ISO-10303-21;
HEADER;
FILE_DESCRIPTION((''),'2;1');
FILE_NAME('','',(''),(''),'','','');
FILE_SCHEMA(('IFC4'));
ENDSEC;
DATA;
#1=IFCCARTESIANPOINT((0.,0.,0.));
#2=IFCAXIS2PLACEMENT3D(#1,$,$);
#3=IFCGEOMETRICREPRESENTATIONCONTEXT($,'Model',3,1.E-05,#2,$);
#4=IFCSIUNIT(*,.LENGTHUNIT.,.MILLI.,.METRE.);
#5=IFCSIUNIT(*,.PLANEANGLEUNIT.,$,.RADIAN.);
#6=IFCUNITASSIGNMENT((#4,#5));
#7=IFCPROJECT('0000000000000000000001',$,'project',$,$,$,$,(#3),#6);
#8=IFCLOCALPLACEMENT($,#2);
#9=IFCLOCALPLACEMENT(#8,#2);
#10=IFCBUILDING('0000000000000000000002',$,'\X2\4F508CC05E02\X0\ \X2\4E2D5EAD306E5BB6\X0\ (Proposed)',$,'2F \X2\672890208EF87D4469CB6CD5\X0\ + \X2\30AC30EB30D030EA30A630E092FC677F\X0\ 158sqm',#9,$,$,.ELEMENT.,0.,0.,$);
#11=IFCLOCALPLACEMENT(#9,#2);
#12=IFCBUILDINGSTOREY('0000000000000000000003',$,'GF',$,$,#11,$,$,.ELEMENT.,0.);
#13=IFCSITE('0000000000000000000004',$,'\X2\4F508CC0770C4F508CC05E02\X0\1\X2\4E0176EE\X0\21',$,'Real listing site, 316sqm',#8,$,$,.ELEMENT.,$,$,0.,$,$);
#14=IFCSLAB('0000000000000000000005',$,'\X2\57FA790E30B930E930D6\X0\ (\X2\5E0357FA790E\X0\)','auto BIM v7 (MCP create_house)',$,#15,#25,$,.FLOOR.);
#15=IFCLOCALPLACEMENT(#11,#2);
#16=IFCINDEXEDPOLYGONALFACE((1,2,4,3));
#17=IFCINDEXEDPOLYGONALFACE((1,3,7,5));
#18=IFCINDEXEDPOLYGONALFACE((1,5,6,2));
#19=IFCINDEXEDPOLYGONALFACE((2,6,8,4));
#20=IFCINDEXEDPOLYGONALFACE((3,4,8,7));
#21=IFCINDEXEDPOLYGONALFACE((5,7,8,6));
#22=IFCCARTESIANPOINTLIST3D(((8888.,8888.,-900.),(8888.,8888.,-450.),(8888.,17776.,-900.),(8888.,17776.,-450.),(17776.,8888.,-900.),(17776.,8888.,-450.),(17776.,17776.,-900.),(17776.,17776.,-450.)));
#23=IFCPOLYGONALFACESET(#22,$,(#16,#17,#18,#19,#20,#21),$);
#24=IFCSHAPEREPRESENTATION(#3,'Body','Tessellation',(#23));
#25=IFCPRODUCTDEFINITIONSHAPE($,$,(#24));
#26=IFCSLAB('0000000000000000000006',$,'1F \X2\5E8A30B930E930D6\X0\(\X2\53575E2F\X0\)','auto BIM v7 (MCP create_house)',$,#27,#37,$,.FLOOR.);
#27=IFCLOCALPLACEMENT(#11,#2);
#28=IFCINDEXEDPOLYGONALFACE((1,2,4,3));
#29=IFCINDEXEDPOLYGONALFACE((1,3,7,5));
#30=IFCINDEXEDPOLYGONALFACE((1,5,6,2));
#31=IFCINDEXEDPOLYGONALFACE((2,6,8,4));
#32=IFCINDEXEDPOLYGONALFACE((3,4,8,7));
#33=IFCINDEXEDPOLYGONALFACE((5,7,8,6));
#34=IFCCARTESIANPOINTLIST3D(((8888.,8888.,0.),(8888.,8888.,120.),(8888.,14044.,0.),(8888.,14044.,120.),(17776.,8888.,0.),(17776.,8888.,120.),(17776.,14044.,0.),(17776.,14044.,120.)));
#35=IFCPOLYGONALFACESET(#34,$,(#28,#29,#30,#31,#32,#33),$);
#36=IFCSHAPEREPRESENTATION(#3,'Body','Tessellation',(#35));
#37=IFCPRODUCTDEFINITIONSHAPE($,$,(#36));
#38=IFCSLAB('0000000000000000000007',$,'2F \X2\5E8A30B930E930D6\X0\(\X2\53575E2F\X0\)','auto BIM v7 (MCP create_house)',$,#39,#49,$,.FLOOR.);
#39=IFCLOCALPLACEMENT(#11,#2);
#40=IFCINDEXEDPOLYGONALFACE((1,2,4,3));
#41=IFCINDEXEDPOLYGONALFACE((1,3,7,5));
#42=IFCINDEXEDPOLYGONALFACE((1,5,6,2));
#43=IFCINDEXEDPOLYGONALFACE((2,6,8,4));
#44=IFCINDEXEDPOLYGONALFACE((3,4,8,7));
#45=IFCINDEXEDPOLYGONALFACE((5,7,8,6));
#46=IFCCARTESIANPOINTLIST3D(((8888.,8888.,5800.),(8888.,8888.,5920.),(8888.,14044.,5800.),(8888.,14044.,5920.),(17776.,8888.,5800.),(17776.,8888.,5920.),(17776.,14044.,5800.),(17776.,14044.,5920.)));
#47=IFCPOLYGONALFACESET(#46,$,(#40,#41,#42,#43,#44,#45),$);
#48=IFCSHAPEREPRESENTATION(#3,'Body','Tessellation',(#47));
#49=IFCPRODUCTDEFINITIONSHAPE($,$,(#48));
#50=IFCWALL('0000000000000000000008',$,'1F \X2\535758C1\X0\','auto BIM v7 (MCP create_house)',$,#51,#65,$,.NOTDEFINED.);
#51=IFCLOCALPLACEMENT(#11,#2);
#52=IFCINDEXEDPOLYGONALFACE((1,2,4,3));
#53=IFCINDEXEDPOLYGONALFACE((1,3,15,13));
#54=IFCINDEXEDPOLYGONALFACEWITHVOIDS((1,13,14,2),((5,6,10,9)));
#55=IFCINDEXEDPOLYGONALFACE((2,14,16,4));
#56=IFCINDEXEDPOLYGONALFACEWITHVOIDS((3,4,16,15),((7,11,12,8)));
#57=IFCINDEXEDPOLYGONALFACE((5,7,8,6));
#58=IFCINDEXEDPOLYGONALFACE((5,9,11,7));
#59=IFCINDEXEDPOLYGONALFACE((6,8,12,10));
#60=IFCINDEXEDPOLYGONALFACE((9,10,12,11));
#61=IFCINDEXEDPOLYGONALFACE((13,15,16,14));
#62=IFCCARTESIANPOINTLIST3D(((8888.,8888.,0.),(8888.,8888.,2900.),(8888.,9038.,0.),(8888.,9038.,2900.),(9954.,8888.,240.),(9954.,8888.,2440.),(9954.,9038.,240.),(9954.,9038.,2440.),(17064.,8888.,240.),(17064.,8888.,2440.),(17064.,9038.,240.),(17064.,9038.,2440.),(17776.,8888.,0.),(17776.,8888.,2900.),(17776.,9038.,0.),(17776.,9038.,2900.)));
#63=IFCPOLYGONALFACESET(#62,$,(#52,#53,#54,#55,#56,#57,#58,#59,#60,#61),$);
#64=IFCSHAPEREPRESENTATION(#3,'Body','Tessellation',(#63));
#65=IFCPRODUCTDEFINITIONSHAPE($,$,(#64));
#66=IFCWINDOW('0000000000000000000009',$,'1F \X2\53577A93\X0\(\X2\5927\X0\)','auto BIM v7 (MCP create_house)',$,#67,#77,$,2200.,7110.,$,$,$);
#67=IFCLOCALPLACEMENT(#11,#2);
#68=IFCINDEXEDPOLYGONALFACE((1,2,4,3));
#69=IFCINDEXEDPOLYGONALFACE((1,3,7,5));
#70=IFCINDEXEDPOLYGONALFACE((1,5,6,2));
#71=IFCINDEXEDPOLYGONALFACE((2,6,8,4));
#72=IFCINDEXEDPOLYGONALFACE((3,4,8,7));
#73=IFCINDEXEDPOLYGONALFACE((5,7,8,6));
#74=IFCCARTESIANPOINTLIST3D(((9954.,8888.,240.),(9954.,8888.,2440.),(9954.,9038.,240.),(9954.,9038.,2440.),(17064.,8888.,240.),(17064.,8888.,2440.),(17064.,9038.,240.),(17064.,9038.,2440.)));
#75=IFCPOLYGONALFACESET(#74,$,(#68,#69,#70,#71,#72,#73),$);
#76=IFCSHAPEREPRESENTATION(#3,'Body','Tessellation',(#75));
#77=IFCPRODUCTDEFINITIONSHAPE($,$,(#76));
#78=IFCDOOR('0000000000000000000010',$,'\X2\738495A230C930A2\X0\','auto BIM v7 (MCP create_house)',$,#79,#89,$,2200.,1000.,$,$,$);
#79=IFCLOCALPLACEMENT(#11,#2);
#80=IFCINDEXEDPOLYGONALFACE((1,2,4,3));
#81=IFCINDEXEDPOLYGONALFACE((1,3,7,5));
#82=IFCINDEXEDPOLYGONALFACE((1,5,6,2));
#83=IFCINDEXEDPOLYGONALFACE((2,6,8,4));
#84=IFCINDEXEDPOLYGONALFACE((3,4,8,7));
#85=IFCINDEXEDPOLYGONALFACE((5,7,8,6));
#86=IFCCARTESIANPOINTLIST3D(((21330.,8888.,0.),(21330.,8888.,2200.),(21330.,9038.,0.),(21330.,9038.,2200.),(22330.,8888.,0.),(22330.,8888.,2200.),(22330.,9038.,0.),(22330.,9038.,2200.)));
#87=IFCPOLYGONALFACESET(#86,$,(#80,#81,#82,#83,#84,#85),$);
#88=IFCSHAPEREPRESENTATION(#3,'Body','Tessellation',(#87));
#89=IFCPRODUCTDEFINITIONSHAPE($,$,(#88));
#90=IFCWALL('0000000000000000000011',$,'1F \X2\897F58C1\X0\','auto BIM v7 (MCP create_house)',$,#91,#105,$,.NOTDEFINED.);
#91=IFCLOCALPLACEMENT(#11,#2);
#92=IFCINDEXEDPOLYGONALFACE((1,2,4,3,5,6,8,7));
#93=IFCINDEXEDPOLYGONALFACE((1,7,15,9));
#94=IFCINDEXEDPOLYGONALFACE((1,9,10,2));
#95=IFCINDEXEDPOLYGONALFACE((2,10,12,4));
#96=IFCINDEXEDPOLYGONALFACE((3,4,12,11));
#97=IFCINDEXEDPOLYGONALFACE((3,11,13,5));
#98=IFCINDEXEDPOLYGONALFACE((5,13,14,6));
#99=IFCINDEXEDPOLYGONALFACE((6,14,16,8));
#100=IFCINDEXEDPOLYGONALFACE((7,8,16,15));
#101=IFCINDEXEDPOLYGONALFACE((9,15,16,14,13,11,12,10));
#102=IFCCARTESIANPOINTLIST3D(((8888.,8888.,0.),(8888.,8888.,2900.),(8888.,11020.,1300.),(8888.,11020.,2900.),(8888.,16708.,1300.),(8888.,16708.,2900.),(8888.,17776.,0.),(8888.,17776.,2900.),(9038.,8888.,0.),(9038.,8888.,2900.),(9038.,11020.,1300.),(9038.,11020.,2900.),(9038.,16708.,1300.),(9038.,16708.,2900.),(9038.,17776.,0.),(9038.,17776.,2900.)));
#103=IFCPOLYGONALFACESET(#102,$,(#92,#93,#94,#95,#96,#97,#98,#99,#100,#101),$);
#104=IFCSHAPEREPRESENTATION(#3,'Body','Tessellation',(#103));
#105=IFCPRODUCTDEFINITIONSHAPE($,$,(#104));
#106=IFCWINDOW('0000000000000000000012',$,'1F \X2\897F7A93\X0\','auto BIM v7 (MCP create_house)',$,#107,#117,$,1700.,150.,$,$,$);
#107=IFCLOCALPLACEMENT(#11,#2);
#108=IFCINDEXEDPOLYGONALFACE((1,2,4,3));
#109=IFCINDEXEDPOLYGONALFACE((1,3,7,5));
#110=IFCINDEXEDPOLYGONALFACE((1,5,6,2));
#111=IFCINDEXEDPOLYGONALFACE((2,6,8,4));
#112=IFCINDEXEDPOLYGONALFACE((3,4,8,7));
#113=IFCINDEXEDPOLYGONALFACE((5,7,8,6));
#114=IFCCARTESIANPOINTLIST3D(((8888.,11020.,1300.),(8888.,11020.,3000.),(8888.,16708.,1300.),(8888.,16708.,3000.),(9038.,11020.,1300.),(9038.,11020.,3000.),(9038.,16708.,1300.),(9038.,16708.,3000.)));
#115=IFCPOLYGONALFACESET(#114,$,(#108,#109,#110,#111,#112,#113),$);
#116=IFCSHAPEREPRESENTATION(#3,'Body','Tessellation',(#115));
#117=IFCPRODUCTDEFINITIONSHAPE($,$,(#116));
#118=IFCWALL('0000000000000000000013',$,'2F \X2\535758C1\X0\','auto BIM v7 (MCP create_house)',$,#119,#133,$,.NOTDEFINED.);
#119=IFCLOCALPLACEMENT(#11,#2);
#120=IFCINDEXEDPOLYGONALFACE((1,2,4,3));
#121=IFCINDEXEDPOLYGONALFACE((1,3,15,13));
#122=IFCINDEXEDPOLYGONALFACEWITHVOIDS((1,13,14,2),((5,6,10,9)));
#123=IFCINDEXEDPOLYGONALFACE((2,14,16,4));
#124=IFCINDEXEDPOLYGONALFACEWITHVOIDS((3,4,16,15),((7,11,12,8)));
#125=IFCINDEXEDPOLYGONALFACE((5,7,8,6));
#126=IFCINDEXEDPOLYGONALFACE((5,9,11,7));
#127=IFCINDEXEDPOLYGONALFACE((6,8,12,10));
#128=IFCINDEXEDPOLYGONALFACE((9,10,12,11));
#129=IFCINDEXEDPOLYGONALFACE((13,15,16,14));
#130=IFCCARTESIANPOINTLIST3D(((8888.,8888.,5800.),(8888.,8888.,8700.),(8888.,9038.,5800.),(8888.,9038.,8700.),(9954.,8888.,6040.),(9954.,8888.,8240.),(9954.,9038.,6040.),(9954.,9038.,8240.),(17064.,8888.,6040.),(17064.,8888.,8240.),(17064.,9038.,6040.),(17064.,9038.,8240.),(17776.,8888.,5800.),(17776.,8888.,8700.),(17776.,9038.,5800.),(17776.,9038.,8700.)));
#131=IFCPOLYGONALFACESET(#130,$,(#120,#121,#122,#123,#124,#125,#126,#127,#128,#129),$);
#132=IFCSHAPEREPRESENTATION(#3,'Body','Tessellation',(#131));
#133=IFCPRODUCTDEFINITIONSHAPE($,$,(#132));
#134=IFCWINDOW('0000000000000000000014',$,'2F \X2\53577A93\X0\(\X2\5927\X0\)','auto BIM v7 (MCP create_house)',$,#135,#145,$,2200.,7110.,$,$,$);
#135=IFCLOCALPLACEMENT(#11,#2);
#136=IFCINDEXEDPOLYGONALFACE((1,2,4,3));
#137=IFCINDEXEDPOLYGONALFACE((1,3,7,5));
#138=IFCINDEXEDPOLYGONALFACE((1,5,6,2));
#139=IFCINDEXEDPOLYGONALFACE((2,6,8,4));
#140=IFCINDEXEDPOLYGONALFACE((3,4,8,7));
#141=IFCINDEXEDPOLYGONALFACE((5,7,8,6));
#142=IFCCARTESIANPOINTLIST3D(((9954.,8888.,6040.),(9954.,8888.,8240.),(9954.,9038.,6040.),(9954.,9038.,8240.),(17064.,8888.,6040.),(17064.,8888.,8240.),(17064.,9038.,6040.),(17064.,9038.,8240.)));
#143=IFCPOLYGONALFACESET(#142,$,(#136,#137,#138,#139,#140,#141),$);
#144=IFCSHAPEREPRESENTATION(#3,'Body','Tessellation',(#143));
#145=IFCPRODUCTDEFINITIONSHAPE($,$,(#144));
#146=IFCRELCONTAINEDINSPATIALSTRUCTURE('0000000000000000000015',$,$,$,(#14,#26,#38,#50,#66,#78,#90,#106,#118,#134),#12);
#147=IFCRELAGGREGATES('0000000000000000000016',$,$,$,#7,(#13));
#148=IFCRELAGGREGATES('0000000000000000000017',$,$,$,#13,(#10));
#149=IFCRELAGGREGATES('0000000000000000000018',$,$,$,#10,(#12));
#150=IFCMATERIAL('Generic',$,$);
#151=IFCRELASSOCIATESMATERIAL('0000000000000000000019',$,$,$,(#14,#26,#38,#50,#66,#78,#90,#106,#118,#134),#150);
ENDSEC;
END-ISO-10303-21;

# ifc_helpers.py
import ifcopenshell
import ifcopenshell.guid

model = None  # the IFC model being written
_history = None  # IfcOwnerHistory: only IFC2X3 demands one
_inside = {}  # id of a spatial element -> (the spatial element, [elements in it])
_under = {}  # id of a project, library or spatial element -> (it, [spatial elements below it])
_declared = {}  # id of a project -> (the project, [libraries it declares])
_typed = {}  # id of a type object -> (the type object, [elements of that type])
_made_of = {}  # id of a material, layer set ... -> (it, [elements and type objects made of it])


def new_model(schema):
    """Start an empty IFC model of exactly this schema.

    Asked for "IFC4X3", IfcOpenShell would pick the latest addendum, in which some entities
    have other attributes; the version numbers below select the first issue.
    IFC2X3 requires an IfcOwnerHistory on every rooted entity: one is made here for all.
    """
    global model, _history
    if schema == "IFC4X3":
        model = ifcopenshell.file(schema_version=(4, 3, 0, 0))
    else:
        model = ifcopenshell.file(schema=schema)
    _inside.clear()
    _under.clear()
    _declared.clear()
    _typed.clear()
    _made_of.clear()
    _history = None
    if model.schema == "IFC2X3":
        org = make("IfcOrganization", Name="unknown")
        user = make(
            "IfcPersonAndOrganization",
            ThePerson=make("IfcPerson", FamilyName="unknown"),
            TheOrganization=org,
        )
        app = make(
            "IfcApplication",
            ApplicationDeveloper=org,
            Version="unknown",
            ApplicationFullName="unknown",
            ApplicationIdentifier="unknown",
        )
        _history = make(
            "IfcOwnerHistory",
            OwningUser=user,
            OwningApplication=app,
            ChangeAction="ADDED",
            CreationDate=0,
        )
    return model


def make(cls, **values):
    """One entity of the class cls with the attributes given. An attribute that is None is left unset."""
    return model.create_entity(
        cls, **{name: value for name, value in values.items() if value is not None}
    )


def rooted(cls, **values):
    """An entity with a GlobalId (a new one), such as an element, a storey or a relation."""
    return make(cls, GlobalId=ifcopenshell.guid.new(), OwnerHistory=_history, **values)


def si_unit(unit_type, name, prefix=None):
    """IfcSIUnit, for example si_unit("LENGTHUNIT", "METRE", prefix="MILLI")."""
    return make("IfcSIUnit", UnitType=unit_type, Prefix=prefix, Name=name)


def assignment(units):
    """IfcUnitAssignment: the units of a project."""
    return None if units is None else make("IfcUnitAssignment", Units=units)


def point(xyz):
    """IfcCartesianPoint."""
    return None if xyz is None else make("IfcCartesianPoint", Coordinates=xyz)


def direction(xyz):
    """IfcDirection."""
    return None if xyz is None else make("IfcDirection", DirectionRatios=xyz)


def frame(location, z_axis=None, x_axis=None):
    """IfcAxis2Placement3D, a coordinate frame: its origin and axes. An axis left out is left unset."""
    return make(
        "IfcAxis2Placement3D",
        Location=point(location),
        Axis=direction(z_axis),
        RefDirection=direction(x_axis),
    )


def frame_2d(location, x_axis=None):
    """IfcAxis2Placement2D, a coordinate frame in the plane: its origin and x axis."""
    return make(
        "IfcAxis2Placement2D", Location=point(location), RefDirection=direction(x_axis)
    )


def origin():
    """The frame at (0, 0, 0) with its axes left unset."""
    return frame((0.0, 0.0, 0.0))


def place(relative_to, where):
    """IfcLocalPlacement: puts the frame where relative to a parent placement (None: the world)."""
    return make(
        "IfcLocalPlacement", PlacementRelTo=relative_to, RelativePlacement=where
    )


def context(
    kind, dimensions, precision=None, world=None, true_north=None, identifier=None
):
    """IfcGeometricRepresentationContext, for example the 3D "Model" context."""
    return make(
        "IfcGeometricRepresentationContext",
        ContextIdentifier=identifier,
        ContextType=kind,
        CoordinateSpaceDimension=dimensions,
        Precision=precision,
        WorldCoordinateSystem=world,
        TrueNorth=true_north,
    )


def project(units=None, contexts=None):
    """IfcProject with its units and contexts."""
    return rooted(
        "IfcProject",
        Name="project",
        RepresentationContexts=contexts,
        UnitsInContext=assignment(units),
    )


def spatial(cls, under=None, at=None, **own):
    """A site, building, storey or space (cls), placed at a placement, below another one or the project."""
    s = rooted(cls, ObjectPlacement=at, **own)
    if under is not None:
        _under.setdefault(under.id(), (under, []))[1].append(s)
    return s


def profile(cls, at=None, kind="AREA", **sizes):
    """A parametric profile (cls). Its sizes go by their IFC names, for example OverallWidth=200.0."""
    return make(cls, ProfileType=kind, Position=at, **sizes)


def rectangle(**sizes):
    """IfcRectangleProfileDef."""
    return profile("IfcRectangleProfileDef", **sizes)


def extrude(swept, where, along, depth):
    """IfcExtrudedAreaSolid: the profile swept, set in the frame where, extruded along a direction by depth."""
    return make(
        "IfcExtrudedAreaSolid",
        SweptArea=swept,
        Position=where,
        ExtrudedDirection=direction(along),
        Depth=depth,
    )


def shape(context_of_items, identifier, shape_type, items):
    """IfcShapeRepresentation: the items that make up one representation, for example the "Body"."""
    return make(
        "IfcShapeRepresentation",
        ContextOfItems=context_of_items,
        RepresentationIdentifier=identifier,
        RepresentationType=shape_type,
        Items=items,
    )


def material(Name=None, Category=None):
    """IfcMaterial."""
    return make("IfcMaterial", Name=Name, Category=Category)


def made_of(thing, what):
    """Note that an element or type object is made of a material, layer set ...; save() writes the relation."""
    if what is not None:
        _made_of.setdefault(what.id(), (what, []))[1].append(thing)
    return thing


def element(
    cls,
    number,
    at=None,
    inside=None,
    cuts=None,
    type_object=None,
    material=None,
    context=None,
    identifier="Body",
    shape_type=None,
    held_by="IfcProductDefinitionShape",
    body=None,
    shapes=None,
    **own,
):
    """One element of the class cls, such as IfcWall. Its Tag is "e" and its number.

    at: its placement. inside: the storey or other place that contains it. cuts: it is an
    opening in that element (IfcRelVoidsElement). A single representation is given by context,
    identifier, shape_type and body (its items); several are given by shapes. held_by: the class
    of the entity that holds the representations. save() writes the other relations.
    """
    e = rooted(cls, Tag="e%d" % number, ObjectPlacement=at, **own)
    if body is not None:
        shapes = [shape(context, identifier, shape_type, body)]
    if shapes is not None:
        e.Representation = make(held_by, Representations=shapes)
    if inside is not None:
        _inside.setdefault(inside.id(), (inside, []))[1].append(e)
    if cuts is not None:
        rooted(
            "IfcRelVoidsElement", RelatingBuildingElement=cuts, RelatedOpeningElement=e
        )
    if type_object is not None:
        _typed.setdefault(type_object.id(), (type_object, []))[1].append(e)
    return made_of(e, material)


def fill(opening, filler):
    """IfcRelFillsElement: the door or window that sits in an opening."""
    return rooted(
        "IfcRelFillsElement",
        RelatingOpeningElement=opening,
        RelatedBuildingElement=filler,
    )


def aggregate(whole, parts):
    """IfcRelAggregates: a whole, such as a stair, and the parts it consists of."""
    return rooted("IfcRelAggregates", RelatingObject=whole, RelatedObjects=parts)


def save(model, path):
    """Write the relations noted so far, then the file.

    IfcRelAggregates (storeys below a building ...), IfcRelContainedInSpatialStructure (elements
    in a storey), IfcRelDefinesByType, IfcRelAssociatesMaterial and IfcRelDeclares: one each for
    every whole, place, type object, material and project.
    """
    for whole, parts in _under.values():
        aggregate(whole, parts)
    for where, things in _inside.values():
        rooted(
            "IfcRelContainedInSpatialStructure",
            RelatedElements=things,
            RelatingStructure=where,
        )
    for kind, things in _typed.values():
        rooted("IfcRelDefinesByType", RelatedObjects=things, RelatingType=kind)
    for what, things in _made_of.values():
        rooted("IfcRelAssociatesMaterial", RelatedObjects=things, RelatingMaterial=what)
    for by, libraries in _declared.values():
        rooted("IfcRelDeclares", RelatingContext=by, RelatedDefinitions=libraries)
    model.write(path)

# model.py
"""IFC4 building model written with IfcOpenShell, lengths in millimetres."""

from ifc_helpers import new_model, si_unit, frame, frame_2d, origin, place, context, project, spatial, rectangle, extrude, material, element, fill, save


model = new_model("IFC4")

# Units and contexts
model_context = context("Model", 3, precision=1e-05, world=origin())
ifc_project = project(units=[si_unit("LENGTHUNIT", "METRE", prefix="MILLI"), si_unit("PLANEANGLEUNIT", "RADIAN")], contexts=[model_context])

# Site, building, storey
site_placement = place(None, origin())
site = spatial("IfcSite", under=ifc_project, at=site_placement, Name="佐賀県佐賀市1丁目21", ObjectType="Real listing site, 316sqm", CompositionType="ELEMENT", RefElevation=0.0)
building_placement = place(site_placement, origin())
building = spatial("IfcBuilding", under=site, at=building_placement, Name="佐賀市 中庭の家 (Proposed)", ObjectType="2F 木造軸組構法 + ガルバリウム鋼板 158sqm", CompositionType="ELEMENT", ElevationOfRefHeight=0.0, ElevationOfTerrain=0.0)
storey_placement = place(building_placement, origin())
storey = spatial("IfcBuildingStorey", under=building, at=storey_placement, Name="GF", CompositionType="ELEMENT", Elevation=0.0)

# Slabs
ifc_material = material(Name="Generic")
slab_1_placement = place(storey_placement, frame((4444.0, 4444.0, -450.0)))
element("IfcSlab", 1, at=slab_1_placement, inside=storey, material=ifc_material, Name="基礎スラブ (布基礎)", Description="auto BIM v7 (MCP create_house)", PredefinedType="FLOOR", context=model_context, shape_type="SweptSolid", body=[
    extrude(rectangle(XDim=8888.0, YDim=8888.0, at=frame_2d((4444.0, 4444.0))), frame((4444.0, 4444.0, -450.0)), (0.0, 0.0, 1.0), 450.0),
])
slab_2_placement = place(storey_placement, frame((4444.0, 4444.0, 0.0)))
element("IfcSlab", 2, at=slab_2_placement, inside=storey, material=ifc_material, Name="1F 床スラブ(南帯)", Description="auto BIM v7 (MCP create_house)", PredefinedType="FLOOR", context=model_context, shape_type="SweptSolid", body=[
    extrude(rectangle(XDim=8888.0, YDim=5156.0, at=frame_2d((4444.0, 2578.0))), frame((4444.0, 4444.0, 0.0)), (0.0, 0.0, 1.0), 120.0),
])
slab_3_placement = place(storey_placement, frame((4444.0, 4444.0, 2900.0)))
element("IfcSlab", 3, at=slab_3_placement, inside=storey, material=ifc_material, Name="2F 床スラブ(南帯)", Description="auto BIM v7 (MCP create_house)", PredefinedType="FLOOR", context=model_context, shape_type="SweptSolid", body=[
    extrude(rectangle(XDim=8888.0, YDim=5156.0, at=frame_2d((4444.0, 2578.0))), frame((4444.0, 4444.0, 2900.0)), (0.0, 0.0, 1.0), 120.0),
])

# Wall, openings, window, door
wall_1_placement = place(storey_placement, frame((4444.0, 4444.0, 0.0)))
wall_1 = element("IfcWall", 4, at=wall_1_placement, inside=storey, material=ifc_material, Name="1F 南壁", Description="auto BIM v7 (MCP create_house)", PredefinedType="NOTDEFINED", context=model_context, shape_type="SweptSolid", body=[
    extrude(rectangle(XDim=8888.0, YDim=150.0, at=frame_2d((4444.0, 75.0))), frame((4444.0, 4444.0, 0.0)), (0.0, 0.0, 1.0), 2900.0),
])
opening_1_placement = place(storey_placement, frame((4977.0, 4444.0, 120.0)))
opening_1 = element("IfcOpeningElement", 5, at=opening_1_placement, cuts=wall_1, PredefinedType="NOTDEFINED", context=model_context, shape_type="SweptSolid", body=[
    extrude(rectangle(XDim=7110.0, YDim=150.0, at=frame_2d((3555.0, 75.0))), frame((4977.0, 4444.0, 120.0)), (0.0, 0.0, 1.0), 2200.0),
])
opening_2_placement = place(storey_placement, frame((10665.0, 4444.0, 0.0)))
opening_2 = element("IfcOpeningElement", 6, at=opening_2_placement, cuts=wall_1, PredefinedType="NOTDEFINED", context=model_context, shape_type="SweptSolid", body=[
    extrude(rectangle(XDim=1000.0, YDim=150.0, at=frame_2d((500.0, 75.0))), frame((10665.0, 4444.0, 0.0)), (0.0, 0.0, 1.0), 2200.0),
])
window_1_placement = place(storey_placement, frame((4977.0, 4444.0, 120.0)))
window_1 = element("IfcWindow", 7, at=window_1_placement, inside=storey, material=ifc_material, Name="1F 南窓(大)", Description="auto BIM v7 (MCP create_house)", OverallHeight=2200.0, OverallWidth=7110.0, context=model_context, shape_type="SweptSolid", body=[
    extrude(rectangle(XDim=7110.0, YDim=150.0, at=frame_2d((3555.0, 75.0))), frame((4977.0, 4444.0, 120.0)), (0.0, 0.0, 1.0), 2200.0),
])
fill(opening_1, window_1)
door_placement = place(storey_placement, frame((10665.0, 4444.0, 0.0)))
door = element("IfcDoor", 8, at=door_placement, inside=storey, material=ifc_material, Name="玄関ドア", Description="auto BIM v7 (MCP create_house)", OverallHeight=2200.0, OverallWidth=1000.0, context=model_context, shape_type="SweptSolid", body=[
    extrude(rectangle(XDim=1000.0, YDim=150.0, at=frame_2d((500.0, 75.0))), frame((10665.0, 4444.0, 0.0)), (0.0, 0.0, 1.0), 2200.0),
])
fill(opening_2, door)

# Wall, opening, window
wall_2_placement = place(storey_placement, frame((4444.0, 4444.0, 0.0)))
wall_2 = element("IfcWall", 9, at=wall_2_placement, inside=storey, material=ifc_material, Name="1F 西壁", Description="auto BIM v7 (MCP create_house)", PredefinedType="NOTDEFINED", context=model_context, shape_type="SweptSolid", body=[
    extrude(rectangle(XDim=150.0, YDim=8888.0, at=frame_2d((75.0, 4444.0))), frame((4444.0, 4444.0, 0.0)), (0.0, 0.0, 1.0), 2900.0),
])
opening_3_placement = place(storey_placement, frame((4444.0, 5510.0, 650.0)))
opening_3 = element("IfcOpeningElement", 10, at=opening_3_placement, cuts=wall_2, PredefinedType="NOTDEFINED", context=model_context, shape_type="SweptSolid", body=[
    extrude(rectangle(XDim=150.0, YDim=5688.0, at=frame_2d((75.0, 2844.0))), frame((4444.0, 5510.0, 650.0)), (0.0, 0.0, 1.0), 1700.0),
])
window_2_placement = place(storey_placement, frame((4444.0, 5510.0, 650.0)))
window_2 = element("IfcWindow", 11, at=window_2_placement, inside=storey, material=ifc_material, Name="1F 西窓", Description="auto BIM v7 (MCP create_house)", OverallHeight=1700.0, OverallWidth=150.0, context=model_context, shape_type="SweptSolid", body=[
    extrude(rectangle(XDim=150.0, YDim=5688.0, at=frame_2d((75.0, 2844.0))), frame((4444.0, 5510.0, 650.0)), (0.0, 0.0, 1.0), 1700.0),
])
fill(opening_3, window_2)

# Wall, opening, window
wall_3_placement = place(storey_placement, frame((4444.0, 4444.0, 2900.0)))
wall_3 = element("IfcWall", 12, at=wall_3_placement, inside=storey, material=ifc_material, Name="2F 南壁", Description="auto BIM v7 (MCP create_house)", PredefinedType="NOTDEFINED", context=model_context, shape_type="SweptSolid", body=[
    extrude(rectangle(XDim=8888.0, YDim=150.0, at=frame_2d((4444.0, 75.0))), frame((4444.0, 4444.0, 2900.0)), (0.0, 0.0, 1.0), 2900.0),
])
opening_4_placement = place(storey_placement, frame((4977.0, 4444.0, 3020.0)))
opening_4 = element("IfcOpeningElement", 13, at=opening_4_placement, cuts=wall_3, PredefinedType="NOTDEFINED", context=model_context, shape_type="SweptSolid", body=[
    extrude(rectangle(XDim=7110.0, YDim=150.0, at=frame_2d((3555.0, 75.0))), frame((4977.0, 4444.0, 3020.0)), (0.0, 0.0, 1.0), 2200.0),
])
window_3_placement = place(storey_placement, frame((4977.0, 4444.0, 3020.0)))
window_3 = element("IfcWindow", 14, at=window_3_placement, inside=storey, material=ifc_material, Name="2F 南窓(大)", Description="auto BIM v7 (MCP create_house)", OverallHeight=2200.0, OverallWidth=7110.0, context=model_context, shape_type="SweptSolid", body=[
    extrude(rectangle(XDim=7110.0, YDim=150.0, at=frame_2d((3555.0, 75.0))), frame((4977.0, 4444.0, 3020.0)), (0.0, 0.0, 1.0), 2200.0),
])
fill(opening_4, window_3)

save(model, "model.ifc")
